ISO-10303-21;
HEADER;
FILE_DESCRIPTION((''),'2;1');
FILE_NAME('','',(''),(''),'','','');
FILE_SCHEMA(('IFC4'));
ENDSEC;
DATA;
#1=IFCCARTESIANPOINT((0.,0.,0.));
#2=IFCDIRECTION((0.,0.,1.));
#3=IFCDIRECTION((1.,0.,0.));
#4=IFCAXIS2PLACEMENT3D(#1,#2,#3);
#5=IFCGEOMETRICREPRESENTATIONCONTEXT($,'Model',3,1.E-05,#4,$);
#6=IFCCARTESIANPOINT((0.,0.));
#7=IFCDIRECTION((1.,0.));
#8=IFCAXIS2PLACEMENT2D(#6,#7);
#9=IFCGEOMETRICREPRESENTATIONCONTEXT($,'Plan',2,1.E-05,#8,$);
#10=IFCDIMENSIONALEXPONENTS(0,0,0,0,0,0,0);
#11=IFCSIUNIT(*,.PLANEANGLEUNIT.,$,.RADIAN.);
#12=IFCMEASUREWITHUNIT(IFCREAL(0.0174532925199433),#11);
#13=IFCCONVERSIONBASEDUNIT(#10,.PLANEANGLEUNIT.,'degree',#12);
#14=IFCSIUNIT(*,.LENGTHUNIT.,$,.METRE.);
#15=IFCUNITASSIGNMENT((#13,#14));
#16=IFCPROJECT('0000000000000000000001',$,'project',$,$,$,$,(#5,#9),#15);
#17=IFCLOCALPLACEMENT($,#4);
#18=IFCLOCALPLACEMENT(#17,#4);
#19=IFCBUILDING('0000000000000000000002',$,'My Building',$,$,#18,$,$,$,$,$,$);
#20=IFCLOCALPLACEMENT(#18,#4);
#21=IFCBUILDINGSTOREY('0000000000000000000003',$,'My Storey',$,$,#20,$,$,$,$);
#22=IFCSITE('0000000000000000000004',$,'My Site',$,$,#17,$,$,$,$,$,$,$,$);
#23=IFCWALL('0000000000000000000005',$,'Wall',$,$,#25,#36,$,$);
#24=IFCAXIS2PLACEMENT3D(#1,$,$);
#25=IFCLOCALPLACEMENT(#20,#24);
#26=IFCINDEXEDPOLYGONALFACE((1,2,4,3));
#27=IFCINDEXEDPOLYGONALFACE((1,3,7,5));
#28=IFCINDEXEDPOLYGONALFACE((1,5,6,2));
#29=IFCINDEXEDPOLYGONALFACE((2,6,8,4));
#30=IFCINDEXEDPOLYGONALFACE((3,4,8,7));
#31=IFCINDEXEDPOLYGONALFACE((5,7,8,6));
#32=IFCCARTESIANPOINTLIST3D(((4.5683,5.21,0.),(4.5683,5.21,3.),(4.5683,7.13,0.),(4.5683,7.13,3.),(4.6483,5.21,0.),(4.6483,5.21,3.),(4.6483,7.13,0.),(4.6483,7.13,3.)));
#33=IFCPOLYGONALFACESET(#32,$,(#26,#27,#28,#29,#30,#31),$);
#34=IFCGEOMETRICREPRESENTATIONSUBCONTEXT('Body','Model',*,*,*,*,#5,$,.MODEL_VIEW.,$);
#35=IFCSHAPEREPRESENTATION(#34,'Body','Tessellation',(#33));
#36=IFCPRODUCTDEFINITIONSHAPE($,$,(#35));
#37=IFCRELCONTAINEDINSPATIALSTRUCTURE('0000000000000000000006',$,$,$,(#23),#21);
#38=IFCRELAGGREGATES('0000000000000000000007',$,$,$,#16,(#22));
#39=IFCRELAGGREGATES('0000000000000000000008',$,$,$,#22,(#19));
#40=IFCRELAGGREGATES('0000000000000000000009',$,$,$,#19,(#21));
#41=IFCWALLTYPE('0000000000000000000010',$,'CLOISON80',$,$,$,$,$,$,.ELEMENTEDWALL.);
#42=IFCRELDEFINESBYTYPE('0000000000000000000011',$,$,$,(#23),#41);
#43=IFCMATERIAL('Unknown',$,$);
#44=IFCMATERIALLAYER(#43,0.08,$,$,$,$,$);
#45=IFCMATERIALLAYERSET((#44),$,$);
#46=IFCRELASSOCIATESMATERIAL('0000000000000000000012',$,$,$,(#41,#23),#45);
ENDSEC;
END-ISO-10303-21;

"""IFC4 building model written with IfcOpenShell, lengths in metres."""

from ifc_helpers import new_model, entity, si_unit, converted_unit, frame, origin_with_axes, origin_2d_with_axis, place, context, subcontext, project, spatial, indexed_curve, outline, extrude, material, layer, layer_set, layer_usage, type_object, element, save


model = new_model("IFC4")

# Units and contexts
model_context = context("Model", 3, precision=1e-05, world=origin_with_axes())
plan_context = context("Plan", 2, precision=1e-05, world=origin_2d_with_axis())
body_context_1 = subcontext(model_context, "Body", "Model", "MODEL_VIEW")
ifc_project = project(units=[converted_unit("PLANEANGLEUNIT", "degree", entity("IfcReal", 0.0174532925199433), si_unit("PLANEANGLEUNIT", "RADIAN"), dimensions=[0, 0, 0, 0, 0, 0, 0]), si_unit("LENGTHUNIT", "METRE")], contexts=[model_context, plan_context])

# Site, building, storey
site_placement = place(None, origin_with_axes())
site = spatial("IfcSite", under=ifc_project, at=site_placement, Name="My Site")
building_placement = place(site_placement, origin_with_axes())
building = spatial("IfcBuilding", under=site, at=building_placement, Name="My Building")
storey_placement = place(building_placement, origin_with_axes())
storey = spatial("IfcBuildingStorey", under=building, at=storey_placement, Name="My Storey")

# Shared definitions
ifc_material = material(Name="Unknown")

# Shared definitions
ifc_layer_1 = layer(ifc_material, 0.08)
ifc_layer_set_1 = layer_set([ifc_layer_1])
wall_type_1 = type_object("IfcWallType", Name="CLOISON80", PredefinedType="ELEMENTEDWALL", material=ifc_layer_set_1)

# Wall
ifc_layer_usage_1 = layer_usage(ifc_layer_set_1, "AXIS2", "POSITIVE", 0.0)
wall_1_placement = place(storey_placement, frame((4.6483, 5.21, 0.0), z_axis=(0.0, 0.0, 1.0), x_axis=(0.0, 1.0, 0.0)))
element("IfcWall", 1, at=wall_1_placement, inside=storey, type_object=wall_type_1, material=ifc_layer_usage_1, Name="Wall", context=body_context_1, shape_type="SweptSolid", body=[
    extrude(outline(indexed_curve([(0.0, 0.0), (0.0, 0.08), (1.92, 0.08), (1.92, 0.0), (0.0, 0.0)], self_intersect=False)), origin_with_axes(), (0.0, 0.0, 1.0), 3.0),
])

save(model, "model.ifc")
